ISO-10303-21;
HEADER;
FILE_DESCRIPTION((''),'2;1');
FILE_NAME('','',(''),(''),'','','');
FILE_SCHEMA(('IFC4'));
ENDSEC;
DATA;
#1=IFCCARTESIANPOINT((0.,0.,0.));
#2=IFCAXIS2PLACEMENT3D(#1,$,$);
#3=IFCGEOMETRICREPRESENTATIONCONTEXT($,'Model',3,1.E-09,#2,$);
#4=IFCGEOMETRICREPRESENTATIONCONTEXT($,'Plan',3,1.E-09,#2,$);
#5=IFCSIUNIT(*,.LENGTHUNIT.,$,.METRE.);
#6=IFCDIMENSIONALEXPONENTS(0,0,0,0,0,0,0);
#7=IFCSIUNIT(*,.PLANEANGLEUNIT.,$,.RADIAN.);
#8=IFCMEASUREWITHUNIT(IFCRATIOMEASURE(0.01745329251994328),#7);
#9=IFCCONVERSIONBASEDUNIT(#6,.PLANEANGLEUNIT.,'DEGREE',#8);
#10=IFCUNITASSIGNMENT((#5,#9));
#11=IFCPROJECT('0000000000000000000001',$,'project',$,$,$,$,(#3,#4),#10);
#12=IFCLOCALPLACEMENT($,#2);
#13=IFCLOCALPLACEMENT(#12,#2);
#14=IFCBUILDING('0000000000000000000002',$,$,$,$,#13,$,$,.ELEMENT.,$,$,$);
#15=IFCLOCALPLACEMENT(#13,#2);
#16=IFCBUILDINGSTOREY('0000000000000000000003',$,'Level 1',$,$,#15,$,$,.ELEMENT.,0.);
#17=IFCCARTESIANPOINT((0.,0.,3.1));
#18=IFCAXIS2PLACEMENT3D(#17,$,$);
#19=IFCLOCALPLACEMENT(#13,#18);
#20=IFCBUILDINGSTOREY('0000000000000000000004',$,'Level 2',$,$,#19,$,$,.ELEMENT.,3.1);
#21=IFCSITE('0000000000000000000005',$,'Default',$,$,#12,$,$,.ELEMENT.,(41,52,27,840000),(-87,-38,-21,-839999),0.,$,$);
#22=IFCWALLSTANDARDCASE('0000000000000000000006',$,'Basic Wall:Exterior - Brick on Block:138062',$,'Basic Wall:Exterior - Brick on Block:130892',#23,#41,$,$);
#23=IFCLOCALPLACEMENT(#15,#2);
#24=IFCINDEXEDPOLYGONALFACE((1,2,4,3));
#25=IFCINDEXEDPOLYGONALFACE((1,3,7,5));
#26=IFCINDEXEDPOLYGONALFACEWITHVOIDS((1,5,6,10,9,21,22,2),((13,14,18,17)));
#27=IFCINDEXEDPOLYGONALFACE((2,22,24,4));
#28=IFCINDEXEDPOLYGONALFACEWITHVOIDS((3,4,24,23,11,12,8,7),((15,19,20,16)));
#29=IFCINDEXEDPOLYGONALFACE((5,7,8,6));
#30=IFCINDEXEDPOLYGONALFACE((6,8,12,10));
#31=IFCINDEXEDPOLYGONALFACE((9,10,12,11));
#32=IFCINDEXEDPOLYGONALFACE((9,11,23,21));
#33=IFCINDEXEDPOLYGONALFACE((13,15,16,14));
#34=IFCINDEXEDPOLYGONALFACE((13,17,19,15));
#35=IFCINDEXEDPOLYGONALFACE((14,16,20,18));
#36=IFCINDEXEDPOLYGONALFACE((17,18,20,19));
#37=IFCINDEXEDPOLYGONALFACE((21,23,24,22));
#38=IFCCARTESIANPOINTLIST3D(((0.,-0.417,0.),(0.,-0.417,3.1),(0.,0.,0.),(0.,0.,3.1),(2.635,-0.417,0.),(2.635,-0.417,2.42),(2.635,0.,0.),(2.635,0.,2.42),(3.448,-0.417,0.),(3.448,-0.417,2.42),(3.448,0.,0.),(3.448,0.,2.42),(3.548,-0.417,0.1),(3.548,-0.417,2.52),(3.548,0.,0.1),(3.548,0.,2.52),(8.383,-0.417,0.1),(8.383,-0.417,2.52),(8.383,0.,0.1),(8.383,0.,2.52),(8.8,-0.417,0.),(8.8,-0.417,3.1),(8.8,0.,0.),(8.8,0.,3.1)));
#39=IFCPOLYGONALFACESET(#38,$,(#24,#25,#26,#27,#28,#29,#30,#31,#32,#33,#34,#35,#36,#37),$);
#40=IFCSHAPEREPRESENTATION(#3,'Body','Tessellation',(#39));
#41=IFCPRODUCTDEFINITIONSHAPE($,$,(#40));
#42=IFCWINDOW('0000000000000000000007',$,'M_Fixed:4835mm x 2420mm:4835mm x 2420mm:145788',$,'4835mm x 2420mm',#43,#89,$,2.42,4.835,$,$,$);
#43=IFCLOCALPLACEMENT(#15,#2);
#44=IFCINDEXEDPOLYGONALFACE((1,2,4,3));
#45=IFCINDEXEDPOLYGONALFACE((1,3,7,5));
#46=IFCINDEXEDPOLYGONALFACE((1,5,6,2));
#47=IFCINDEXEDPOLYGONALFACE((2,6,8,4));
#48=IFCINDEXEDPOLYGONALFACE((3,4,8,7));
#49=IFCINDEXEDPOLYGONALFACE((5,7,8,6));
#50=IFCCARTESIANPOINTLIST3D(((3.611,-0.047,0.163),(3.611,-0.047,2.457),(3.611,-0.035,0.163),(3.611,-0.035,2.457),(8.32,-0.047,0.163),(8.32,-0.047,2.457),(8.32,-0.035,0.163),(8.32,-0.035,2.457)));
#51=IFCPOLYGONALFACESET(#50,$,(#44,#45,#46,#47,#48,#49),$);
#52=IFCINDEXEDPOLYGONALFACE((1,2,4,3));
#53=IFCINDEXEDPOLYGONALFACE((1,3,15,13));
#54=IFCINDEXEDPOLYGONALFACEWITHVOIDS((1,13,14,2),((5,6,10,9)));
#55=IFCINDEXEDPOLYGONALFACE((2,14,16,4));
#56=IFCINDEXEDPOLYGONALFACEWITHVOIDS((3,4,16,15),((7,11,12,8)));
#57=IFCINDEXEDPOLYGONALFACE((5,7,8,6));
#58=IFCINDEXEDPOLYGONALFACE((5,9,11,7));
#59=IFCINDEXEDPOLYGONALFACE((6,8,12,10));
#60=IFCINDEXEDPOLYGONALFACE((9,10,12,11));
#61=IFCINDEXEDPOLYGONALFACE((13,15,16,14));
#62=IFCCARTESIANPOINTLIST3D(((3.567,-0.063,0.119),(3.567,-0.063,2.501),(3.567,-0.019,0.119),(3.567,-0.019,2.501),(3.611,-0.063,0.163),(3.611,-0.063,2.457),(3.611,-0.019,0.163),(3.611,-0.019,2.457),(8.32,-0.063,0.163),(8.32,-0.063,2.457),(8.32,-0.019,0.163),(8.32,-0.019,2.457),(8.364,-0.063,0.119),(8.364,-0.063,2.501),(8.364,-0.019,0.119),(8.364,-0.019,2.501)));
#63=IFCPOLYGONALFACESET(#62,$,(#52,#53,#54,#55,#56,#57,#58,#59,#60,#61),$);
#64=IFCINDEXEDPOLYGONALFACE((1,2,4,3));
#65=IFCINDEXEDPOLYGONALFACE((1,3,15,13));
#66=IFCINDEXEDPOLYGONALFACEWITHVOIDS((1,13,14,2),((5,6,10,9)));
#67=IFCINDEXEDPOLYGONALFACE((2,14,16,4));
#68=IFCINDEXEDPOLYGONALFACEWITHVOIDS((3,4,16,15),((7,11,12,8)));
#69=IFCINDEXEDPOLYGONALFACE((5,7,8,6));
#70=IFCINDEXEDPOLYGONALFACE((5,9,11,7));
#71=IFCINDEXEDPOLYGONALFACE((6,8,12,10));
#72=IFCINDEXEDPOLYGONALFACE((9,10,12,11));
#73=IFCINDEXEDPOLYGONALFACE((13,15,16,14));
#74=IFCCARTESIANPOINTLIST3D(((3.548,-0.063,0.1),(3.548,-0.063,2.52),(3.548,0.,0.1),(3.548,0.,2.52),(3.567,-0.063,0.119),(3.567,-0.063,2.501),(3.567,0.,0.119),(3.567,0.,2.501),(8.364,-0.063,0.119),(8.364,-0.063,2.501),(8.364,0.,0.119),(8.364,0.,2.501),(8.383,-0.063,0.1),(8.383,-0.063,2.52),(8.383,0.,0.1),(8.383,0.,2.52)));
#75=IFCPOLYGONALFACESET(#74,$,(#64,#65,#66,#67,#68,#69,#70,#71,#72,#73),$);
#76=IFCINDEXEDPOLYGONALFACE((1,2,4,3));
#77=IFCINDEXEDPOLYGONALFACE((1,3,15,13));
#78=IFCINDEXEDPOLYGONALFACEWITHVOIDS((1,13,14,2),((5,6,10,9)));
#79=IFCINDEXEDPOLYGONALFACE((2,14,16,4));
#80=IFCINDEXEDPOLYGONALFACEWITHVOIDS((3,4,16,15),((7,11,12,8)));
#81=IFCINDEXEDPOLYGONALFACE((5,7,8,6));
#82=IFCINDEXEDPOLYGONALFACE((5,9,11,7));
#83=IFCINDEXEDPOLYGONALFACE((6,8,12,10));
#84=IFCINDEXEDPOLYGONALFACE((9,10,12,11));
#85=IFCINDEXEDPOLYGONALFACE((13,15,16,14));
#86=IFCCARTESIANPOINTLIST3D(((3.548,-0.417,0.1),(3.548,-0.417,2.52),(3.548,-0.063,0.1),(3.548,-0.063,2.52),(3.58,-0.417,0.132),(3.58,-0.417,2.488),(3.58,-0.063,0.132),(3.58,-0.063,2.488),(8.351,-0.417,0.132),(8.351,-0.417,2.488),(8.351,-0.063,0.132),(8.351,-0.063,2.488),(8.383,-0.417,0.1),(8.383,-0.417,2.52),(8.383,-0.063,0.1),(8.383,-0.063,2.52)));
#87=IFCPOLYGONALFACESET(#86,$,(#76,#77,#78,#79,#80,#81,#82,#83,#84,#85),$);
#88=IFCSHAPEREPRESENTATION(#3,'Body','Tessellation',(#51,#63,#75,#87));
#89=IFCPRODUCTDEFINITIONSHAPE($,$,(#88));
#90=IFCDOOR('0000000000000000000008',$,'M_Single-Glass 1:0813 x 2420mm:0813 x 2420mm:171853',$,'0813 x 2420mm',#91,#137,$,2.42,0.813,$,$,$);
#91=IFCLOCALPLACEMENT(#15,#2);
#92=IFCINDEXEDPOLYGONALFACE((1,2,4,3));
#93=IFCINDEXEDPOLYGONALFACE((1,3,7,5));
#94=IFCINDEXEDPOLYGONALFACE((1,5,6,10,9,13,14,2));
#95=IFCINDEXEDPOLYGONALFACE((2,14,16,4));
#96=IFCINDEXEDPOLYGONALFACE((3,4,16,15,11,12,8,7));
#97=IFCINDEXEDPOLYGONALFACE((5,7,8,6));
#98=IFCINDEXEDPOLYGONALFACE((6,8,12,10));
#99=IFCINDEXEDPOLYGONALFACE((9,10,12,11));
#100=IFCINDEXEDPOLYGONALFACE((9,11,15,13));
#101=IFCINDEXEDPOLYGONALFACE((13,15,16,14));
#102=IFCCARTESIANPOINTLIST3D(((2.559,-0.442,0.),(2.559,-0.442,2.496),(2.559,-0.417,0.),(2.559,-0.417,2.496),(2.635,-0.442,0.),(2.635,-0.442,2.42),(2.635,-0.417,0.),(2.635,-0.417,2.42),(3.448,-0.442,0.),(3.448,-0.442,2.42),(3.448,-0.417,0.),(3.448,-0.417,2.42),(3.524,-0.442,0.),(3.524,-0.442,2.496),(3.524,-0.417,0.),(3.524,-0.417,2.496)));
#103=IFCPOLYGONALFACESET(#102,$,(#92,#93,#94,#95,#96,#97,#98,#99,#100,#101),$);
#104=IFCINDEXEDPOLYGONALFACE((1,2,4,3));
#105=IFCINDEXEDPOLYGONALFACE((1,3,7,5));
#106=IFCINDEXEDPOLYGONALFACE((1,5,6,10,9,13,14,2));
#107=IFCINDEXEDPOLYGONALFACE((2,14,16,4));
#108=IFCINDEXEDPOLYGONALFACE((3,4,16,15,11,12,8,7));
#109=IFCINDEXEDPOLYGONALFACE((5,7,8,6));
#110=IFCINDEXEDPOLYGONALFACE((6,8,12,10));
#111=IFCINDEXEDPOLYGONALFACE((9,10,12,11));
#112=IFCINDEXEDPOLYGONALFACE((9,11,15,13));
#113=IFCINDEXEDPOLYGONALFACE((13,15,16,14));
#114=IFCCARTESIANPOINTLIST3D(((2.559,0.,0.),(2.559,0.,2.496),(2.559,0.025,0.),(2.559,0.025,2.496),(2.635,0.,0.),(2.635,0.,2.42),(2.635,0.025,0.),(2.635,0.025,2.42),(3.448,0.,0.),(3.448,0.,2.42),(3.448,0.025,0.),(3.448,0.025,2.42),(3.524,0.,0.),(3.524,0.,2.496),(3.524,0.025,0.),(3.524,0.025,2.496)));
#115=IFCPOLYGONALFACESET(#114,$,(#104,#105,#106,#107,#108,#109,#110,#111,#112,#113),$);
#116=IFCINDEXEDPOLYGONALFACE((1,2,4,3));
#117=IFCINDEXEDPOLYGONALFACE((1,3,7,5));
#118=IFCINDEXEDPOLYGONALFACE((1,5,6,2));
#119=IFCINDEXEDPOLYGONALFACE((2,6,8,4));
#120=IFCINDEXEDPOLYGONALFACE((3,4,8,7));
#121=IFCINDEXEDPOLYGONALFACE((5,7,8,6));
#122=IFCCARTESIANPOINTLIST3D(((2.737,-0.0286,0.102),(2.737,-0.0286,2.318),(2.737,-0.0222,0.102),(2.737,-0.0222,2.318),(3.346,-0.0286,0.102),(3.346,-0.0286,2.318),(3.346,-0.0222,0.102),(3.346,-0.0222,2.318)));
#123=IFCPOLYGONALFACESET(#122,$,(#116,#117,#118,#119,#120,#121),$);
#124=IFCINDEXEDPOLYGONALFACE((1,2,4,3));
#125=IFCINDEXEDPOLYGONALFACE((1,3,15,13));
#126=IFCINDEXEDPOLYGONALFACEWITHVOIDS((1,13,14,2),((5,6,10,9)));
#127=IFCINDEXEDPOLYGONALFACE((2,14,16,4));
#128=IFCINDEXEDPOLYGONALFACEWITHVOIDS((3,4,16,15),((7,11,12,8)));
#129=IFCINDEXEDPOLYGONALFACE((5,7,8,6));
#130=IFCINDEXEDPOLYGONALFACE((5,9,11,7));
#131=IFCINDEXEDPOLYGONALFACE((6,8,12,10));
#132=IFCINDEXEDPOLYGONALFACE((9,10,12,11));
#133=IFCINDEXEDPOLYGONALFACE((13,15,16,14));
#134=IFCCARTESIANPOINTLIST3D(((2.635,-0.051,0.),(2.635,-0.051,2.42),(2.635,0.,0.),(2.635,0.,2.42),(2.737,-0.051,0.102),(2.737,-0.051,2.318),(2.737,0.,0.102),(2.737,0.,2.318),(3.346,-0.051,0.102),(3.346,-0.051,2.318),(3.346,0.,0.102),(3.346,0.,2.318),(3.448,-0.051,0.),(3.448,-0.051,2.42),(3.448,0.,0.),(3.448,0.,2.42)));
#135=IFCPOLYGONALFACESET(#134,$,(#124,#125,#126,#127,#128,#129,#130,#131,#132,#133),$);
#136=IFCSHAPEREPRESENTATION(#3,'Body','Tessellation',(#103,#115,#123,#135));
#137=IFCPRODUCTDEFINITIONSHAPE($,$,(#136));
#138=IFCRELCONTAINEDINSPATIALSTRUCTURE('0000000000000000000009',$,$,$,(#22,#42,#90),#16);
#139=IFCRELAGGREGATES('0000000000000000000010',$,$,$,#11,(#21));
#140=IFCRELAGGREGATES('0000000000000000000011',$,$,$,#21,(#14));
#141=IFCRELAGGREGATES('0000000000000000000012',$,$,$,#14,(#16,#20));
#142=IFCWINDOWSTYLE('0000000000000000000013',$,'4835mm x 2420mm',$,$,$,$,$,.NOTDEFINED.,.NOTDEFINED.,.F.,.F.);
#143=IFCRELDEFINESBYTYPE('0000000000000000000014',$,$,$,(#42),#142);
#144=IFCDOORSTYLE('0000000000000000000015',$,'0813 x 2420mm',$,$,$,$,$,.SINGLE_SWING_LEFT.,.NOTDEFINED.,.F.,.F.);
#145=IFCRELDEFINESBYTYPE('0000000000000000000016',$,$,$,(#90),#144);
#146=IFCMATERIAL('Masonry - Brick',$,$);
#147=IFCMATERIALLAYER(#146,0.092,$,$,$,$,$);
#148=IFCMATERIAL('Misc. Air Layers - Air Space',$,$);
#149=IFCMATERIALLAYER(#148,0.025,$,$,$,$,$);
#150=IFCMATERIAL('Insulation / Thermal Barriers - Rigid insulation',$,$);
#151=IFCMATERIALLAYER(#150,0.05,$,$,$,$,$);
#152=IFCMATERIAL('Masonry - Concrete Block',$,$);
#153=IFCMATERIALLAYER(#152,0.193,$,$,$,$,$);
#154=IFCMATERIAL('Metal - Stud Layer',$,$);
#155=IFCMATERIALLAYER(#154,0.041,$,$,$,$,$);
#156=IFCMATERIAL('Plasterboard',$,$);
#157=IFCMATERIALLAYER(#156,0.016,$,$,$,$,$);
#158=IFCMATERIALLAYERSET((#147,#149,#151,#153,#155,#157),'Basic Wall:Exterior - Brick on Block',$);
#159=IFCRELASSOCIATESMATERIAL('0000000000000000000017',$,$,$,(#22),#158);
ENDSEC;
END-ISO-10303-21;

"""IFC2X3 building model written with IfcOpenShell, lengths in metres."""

from ifc_helpers import new_model, entity, si_unit, converted_unit, frame, frame_2d, origin, origin_2d_with_axis, place, context, project, spatial, polyline, rectangle, outline, extrude, source, transform, mapped, material, layer, layer_set, layer_usage, type_object, type_shapes, element, fill, save


model = new_model("IFC2X3")

# Units and contexts
model_context = context("Model", 3, precision=1e-09, world=origin())
plan_context = context("Plan", 3, precision=1e-09, world=origin())
ifc_project = project(units=[si_unit("LENGTHUNIT", "METRE"), converted_unit("PLANEANGLEUNIT", "DEGREE", entity("IfcRatioMeasure", 0.01745329251994328), si_unit("PLANEANGLEUNIT", "RADIAN"), dimensions=[0, 0, 0, 0, 0, 0, 0])], contexts=[model_context, plan_context])

# Site, building, storey
site_placement = place(None, origin())
site = spatial("IfcSite", under=ifc_project, at=site_placement, Name="Default", CompositionType="ELEMENT", RefLatitude=(41, 52, 27, 840000), RefLongitude=(-87, -38, -21, -839999), RefElevation=0.0)
building_placement = place(site_placement, origin())
building = spatial("IfcBuilding", under=site, at=building_placement, CompositionType="ELEMENT")
storey_1_placement = place(building_placement, origin())
storey_1 = spatial("IfcBuildingStorey", under=building, at=storey_1_placement, Name="Level 1", CompositionType="ELEMENT", Elevation=0.0)

# Wall, openings, window, door
ifc_material_1 = material(Name="Masonry - Brick")
ifc_layer_1 = layer(ifc_material_1, 0.092)
ifc_material_2 = material(Name="Misc. Air Layers - Air Space")
ifc_layer_2 = layer(ifc_material_2, 0.025)
ifc_material_3 = material(Name="Insulation / Thermal Barriers - Rigid insulation")
ifc_layer_3 = layer(ifc_material_3, 0.05)
ifc_material_4 = material(Name="Masonry - Concrete Block")
ifc_layer_4 = layer(ifc_material_4, 0.193)
ifc_material_5 = material(Name="Metal - Stud Layer")
ifc_layer_5 = layer(ifc_material_5, 0.041)
ifc_material_6 = material(Name="Plasterboard")
ifc_layer_6 = layer(ifc_material_6, 0.016)
ifc_layer_set_1 = layer_set([ifc_layer_1, ifc_layer_2, ifc_layer_3, ifc_layer_4, ifc_layer_5, ifc_layer_6], Name="Basic Wall:Exterior - Brick on Block")
ifc_layer_usage_1 = layer_usage(ifc_layer_set_1, "AXIS2", "NEGATIVE", 0.2085)
wall_1_placement = place(storey_1_placement, frame((0.0, -0.2085, 0.0)))
wall_1 = element("IfcWallStandardCase", 1, at=wall_1_placement, inside=storey_1, material=ifc_layer_usage_1, Name="Basic Wall:Exterior - Brick on Block:138062", ObjectType="Basic Wall:Exterior - Brick on Block:130892", context=model_context, shape_type="SweptSolid", body=[
    extrude(rectangle(XDim=8.8, YDim=0.417, at=frame_2d((4.4, 0.0), x_axis=(-1.0, 0.0))), origin(), (0.0, 0.0, 1.0), 3.1),
])
opening_1_placement = place(wall_1_placement, frame((3.548, -0.2085, 0.1)))
opening_1 = element("IfcOpeningElement", 2, at=opening_1_placement, cuts=wall_1, ObjectType="Opening", context=model_context, shape_type="SweptSolid", body=[
    extrude(rectangle(XDim=2.42, YDim=4.835, at=frame_2d((1.21, 2.4175), x_axis=(1.0, 0.0))), frame((0.0, 0.0, 0.0), z_axis=(0.0, 1.0, 0.0), x_axis=(0.0, 0.0, 1.0)), (0.0, 0.0, 1.0), 0.417),
])
opening_2_placement = place(wall_1_placement, frame((2.635, -0.2085, 0.0)))
opening_2 = element("IfcOpeningElement", 3, at=opening_2_placement, cuts=wall_1, ObjectType="Opening", context=model_context, shape_type="SweptSolid", body=[
    extrude(rectangle(XDim=0.813, YDim=2.42, at=frame_2d((1.21, 0.4065), x_axis=(0.0, -1.0))), frame((0.0, 0.0, 0.0), z_axis=(0.0, 1.0, 0.0), x_axis=(0.0, 0.0, 1.0)), (0.0, 0.0, 1.0), 0.417),
])
window_style = type_object("IfcWindowStyle", Name="4835mm x 2420mm", ConstructionType="NOTDEFINED", OperationType="NOTDEFINED", ParameterTakesPrecedence=False, Sizeable=False)
shared_shape_1 = source(origin(), model_context, "Body", "SweptSolid", [
    extrude(rectangle(XDim=0.012, YDim=4.709, at=origin_2d_with_axis()), frame((2.4175, 0.376, 0.063), z_axis=(0.0, 0.0, 1.0), x_axis=(0.0, -1.0, 0.0)), (0.0, 0.0, 1.0), 2.294),
    extrude(outline(polyline([(-2.3985, -1.191), (2.3985, -1.191), (2.3985, 1.191), (-2.3985, 1.191), (-2.3985, -1.191)]), holes=[polyline([(-2.3545, -1.147), (-2.3545, 1.147), (2.3545, 1.147), (2.3545, -1.147), (-2.3545, -1.147)])]), frame((2.4175, 0.354, 1.21), z_axis=(0.0, 1.0, 0.0), x_axis=(1.0, 0.0, 0.0)), (0.0, 0.0, 1.0), 0.044),
    extrude(outline(polyline([(-2.4175, -1.21), (2.4175, -1.21), (2.4175, 1.21), (-2.4175, 1.21), (-2.4175, -1.21)]), holes=[polyline([(-2.3985, -1.191), (-2.3985, 1.191), (2.3985, 1.191), (2.3985, -1.191), (-2.3985, -1.191)])]), frame((2.4175, 0.354, 1.21), z_axis=(0.0, 1.0, 0.0), x_axis=(1.0, 0.0, 0.0)), (0.0, 0.0, 1.0), 0.063),
    extrude(outline(polyline([(-2.4175, -1.21), (2.4175, -1.21), (2.4175, 1.21), (-2.4175, 1.21), (-2.4175, -1.21)]), holes=[polyline([(-2.3855, -1.178), (-2.3855, 1.178), (2.3855, 1.178), (2.3855, -1.178), (-2.3855, -1.178)])]), frame((2.4175, 0.0, 1.21), z_axis=(0.0, 1.0, 0.0), x_axis=(1.0, 0.0, 0.0)), (0.0, 0.0, 1.0), 0.354),
])
type_shapes(window_style, [shared_shape_1])
window_placement = place(opening_1_placement, origin())
window = element("IfcWindow", 4, at=window_placement, inside=storey_1, type_object=window_style, Name="M_Fixed:4835mm x 2420mm:4835mm x 2420mm:145788", ObjectType="4835mm x 2420mm", OverallHeight=2.42, OverallWidth=4.835, context=model_context, shape_type="MappedRepresentation", body=[
    mapped(shared_shape_1, transform((0.0, 0.0, 0.0), scale=1.0)),
])
fill(opening_1, window)
door_style_1 = type_object("IfcDoorStyle", Name="0813 x 2420mm", ConstructionType="NOTDEFINED", OperationType="SINGLE_SWING_LEFT", ParameterTakesPrecedence=False, Sizeable=False)
shared_shape_2 = source(origin(), model_context, "Body", "SweptSolid", [
    extrude(outline(polyline([(-0.4065, -1.191), (-0.4065, 1.229), (-0.4825, 1.229), (-0.4825, -1.267), (0.4825, -1.267), (0.4825, 1.229), (0.4065, 1.229), (0.4065, -1.191), (-0.4065, -1.191)])), frame((0.4065, 0.0, 1.229), z_axis=(0.0, 1.0, 0.0), x_axis=(1.0, 0.0, 0.0)), (0.0, 0.0, -1.0), 0.025),
    extrude(outline(polyline([(-0.4065, -1.191), (-0.4065, 1.229), (-0.4825, 1.229), (-0.4825, -1.267), (0.4825, -1.267), (0.4825, 1.229), (0.4065, 1.229), (0.4065, -1.191), (-0.4065, -1.191)])), frame((0.4065, 0.442, 1.229), z_axis=(0.0, 1.0, 0.0), x_axis=(1.0, 0.0, 0.0)), (0.0, 0.0, -1.0), 0.025),
    extrude(rectangle(XDim=0.609, YDim=0.0064, at=origin_2d_with_axis()), frame((0.4065, 0.3916, 0.102)), (0.0, 0.0, 1.0), 2.216),
    extrude(outline(polyline([(-1.21, -0.4065), (1.21, -0.4065), (1.21, 0.4065), (-1.21, 0.4065), (-1.21, -0.4065)]), holes=[polyline([(-1.108, 0.3045), (1.108, 0.3045), (1.108, -0.3045), (-1.108, -0.3045), (-1.108, 0.3045)])]), frame((0.4065, 0.417, 1.21), z_axis=(0.0, -1.0, 0.0), x_axis=(0.0, 0.0, -1.0)), (0.0, 0.0, 1.0), 0.051),
])
type_shapes(door_style_1, [shared_shape_2])
door_1_placement = place(opening_2_placement, origin())
door_1 = element("IfcDoor", 5, at=door_1_placement, inside=storey_1, type_object=door_style_1, Name="M_Single-Glass 1:0813 x 2420mm:0813 x 2420mm:171853", ObjectType="0813 x 2420mm", OverallHeight=2.42, OverallWidth=0.813, context=model_context, shape_type="MappedRepresentation", body=[
    mapped(shared_shape_2, transform((0.0, 0.0, 0.0), scale=1.0)),
])
fill(opening_2, door_1)

# Shared definitions
storey_2_placement = place(building_placement, frame((0.0, 0.0, 3.1)))
storey_2 = spatial("IfcBuildingStorey", under=building, at=storey_2_placement, Name="Level 2", CompositionType="ELEMENT", Elevation=3.1)

save(model, "model.ifc")
